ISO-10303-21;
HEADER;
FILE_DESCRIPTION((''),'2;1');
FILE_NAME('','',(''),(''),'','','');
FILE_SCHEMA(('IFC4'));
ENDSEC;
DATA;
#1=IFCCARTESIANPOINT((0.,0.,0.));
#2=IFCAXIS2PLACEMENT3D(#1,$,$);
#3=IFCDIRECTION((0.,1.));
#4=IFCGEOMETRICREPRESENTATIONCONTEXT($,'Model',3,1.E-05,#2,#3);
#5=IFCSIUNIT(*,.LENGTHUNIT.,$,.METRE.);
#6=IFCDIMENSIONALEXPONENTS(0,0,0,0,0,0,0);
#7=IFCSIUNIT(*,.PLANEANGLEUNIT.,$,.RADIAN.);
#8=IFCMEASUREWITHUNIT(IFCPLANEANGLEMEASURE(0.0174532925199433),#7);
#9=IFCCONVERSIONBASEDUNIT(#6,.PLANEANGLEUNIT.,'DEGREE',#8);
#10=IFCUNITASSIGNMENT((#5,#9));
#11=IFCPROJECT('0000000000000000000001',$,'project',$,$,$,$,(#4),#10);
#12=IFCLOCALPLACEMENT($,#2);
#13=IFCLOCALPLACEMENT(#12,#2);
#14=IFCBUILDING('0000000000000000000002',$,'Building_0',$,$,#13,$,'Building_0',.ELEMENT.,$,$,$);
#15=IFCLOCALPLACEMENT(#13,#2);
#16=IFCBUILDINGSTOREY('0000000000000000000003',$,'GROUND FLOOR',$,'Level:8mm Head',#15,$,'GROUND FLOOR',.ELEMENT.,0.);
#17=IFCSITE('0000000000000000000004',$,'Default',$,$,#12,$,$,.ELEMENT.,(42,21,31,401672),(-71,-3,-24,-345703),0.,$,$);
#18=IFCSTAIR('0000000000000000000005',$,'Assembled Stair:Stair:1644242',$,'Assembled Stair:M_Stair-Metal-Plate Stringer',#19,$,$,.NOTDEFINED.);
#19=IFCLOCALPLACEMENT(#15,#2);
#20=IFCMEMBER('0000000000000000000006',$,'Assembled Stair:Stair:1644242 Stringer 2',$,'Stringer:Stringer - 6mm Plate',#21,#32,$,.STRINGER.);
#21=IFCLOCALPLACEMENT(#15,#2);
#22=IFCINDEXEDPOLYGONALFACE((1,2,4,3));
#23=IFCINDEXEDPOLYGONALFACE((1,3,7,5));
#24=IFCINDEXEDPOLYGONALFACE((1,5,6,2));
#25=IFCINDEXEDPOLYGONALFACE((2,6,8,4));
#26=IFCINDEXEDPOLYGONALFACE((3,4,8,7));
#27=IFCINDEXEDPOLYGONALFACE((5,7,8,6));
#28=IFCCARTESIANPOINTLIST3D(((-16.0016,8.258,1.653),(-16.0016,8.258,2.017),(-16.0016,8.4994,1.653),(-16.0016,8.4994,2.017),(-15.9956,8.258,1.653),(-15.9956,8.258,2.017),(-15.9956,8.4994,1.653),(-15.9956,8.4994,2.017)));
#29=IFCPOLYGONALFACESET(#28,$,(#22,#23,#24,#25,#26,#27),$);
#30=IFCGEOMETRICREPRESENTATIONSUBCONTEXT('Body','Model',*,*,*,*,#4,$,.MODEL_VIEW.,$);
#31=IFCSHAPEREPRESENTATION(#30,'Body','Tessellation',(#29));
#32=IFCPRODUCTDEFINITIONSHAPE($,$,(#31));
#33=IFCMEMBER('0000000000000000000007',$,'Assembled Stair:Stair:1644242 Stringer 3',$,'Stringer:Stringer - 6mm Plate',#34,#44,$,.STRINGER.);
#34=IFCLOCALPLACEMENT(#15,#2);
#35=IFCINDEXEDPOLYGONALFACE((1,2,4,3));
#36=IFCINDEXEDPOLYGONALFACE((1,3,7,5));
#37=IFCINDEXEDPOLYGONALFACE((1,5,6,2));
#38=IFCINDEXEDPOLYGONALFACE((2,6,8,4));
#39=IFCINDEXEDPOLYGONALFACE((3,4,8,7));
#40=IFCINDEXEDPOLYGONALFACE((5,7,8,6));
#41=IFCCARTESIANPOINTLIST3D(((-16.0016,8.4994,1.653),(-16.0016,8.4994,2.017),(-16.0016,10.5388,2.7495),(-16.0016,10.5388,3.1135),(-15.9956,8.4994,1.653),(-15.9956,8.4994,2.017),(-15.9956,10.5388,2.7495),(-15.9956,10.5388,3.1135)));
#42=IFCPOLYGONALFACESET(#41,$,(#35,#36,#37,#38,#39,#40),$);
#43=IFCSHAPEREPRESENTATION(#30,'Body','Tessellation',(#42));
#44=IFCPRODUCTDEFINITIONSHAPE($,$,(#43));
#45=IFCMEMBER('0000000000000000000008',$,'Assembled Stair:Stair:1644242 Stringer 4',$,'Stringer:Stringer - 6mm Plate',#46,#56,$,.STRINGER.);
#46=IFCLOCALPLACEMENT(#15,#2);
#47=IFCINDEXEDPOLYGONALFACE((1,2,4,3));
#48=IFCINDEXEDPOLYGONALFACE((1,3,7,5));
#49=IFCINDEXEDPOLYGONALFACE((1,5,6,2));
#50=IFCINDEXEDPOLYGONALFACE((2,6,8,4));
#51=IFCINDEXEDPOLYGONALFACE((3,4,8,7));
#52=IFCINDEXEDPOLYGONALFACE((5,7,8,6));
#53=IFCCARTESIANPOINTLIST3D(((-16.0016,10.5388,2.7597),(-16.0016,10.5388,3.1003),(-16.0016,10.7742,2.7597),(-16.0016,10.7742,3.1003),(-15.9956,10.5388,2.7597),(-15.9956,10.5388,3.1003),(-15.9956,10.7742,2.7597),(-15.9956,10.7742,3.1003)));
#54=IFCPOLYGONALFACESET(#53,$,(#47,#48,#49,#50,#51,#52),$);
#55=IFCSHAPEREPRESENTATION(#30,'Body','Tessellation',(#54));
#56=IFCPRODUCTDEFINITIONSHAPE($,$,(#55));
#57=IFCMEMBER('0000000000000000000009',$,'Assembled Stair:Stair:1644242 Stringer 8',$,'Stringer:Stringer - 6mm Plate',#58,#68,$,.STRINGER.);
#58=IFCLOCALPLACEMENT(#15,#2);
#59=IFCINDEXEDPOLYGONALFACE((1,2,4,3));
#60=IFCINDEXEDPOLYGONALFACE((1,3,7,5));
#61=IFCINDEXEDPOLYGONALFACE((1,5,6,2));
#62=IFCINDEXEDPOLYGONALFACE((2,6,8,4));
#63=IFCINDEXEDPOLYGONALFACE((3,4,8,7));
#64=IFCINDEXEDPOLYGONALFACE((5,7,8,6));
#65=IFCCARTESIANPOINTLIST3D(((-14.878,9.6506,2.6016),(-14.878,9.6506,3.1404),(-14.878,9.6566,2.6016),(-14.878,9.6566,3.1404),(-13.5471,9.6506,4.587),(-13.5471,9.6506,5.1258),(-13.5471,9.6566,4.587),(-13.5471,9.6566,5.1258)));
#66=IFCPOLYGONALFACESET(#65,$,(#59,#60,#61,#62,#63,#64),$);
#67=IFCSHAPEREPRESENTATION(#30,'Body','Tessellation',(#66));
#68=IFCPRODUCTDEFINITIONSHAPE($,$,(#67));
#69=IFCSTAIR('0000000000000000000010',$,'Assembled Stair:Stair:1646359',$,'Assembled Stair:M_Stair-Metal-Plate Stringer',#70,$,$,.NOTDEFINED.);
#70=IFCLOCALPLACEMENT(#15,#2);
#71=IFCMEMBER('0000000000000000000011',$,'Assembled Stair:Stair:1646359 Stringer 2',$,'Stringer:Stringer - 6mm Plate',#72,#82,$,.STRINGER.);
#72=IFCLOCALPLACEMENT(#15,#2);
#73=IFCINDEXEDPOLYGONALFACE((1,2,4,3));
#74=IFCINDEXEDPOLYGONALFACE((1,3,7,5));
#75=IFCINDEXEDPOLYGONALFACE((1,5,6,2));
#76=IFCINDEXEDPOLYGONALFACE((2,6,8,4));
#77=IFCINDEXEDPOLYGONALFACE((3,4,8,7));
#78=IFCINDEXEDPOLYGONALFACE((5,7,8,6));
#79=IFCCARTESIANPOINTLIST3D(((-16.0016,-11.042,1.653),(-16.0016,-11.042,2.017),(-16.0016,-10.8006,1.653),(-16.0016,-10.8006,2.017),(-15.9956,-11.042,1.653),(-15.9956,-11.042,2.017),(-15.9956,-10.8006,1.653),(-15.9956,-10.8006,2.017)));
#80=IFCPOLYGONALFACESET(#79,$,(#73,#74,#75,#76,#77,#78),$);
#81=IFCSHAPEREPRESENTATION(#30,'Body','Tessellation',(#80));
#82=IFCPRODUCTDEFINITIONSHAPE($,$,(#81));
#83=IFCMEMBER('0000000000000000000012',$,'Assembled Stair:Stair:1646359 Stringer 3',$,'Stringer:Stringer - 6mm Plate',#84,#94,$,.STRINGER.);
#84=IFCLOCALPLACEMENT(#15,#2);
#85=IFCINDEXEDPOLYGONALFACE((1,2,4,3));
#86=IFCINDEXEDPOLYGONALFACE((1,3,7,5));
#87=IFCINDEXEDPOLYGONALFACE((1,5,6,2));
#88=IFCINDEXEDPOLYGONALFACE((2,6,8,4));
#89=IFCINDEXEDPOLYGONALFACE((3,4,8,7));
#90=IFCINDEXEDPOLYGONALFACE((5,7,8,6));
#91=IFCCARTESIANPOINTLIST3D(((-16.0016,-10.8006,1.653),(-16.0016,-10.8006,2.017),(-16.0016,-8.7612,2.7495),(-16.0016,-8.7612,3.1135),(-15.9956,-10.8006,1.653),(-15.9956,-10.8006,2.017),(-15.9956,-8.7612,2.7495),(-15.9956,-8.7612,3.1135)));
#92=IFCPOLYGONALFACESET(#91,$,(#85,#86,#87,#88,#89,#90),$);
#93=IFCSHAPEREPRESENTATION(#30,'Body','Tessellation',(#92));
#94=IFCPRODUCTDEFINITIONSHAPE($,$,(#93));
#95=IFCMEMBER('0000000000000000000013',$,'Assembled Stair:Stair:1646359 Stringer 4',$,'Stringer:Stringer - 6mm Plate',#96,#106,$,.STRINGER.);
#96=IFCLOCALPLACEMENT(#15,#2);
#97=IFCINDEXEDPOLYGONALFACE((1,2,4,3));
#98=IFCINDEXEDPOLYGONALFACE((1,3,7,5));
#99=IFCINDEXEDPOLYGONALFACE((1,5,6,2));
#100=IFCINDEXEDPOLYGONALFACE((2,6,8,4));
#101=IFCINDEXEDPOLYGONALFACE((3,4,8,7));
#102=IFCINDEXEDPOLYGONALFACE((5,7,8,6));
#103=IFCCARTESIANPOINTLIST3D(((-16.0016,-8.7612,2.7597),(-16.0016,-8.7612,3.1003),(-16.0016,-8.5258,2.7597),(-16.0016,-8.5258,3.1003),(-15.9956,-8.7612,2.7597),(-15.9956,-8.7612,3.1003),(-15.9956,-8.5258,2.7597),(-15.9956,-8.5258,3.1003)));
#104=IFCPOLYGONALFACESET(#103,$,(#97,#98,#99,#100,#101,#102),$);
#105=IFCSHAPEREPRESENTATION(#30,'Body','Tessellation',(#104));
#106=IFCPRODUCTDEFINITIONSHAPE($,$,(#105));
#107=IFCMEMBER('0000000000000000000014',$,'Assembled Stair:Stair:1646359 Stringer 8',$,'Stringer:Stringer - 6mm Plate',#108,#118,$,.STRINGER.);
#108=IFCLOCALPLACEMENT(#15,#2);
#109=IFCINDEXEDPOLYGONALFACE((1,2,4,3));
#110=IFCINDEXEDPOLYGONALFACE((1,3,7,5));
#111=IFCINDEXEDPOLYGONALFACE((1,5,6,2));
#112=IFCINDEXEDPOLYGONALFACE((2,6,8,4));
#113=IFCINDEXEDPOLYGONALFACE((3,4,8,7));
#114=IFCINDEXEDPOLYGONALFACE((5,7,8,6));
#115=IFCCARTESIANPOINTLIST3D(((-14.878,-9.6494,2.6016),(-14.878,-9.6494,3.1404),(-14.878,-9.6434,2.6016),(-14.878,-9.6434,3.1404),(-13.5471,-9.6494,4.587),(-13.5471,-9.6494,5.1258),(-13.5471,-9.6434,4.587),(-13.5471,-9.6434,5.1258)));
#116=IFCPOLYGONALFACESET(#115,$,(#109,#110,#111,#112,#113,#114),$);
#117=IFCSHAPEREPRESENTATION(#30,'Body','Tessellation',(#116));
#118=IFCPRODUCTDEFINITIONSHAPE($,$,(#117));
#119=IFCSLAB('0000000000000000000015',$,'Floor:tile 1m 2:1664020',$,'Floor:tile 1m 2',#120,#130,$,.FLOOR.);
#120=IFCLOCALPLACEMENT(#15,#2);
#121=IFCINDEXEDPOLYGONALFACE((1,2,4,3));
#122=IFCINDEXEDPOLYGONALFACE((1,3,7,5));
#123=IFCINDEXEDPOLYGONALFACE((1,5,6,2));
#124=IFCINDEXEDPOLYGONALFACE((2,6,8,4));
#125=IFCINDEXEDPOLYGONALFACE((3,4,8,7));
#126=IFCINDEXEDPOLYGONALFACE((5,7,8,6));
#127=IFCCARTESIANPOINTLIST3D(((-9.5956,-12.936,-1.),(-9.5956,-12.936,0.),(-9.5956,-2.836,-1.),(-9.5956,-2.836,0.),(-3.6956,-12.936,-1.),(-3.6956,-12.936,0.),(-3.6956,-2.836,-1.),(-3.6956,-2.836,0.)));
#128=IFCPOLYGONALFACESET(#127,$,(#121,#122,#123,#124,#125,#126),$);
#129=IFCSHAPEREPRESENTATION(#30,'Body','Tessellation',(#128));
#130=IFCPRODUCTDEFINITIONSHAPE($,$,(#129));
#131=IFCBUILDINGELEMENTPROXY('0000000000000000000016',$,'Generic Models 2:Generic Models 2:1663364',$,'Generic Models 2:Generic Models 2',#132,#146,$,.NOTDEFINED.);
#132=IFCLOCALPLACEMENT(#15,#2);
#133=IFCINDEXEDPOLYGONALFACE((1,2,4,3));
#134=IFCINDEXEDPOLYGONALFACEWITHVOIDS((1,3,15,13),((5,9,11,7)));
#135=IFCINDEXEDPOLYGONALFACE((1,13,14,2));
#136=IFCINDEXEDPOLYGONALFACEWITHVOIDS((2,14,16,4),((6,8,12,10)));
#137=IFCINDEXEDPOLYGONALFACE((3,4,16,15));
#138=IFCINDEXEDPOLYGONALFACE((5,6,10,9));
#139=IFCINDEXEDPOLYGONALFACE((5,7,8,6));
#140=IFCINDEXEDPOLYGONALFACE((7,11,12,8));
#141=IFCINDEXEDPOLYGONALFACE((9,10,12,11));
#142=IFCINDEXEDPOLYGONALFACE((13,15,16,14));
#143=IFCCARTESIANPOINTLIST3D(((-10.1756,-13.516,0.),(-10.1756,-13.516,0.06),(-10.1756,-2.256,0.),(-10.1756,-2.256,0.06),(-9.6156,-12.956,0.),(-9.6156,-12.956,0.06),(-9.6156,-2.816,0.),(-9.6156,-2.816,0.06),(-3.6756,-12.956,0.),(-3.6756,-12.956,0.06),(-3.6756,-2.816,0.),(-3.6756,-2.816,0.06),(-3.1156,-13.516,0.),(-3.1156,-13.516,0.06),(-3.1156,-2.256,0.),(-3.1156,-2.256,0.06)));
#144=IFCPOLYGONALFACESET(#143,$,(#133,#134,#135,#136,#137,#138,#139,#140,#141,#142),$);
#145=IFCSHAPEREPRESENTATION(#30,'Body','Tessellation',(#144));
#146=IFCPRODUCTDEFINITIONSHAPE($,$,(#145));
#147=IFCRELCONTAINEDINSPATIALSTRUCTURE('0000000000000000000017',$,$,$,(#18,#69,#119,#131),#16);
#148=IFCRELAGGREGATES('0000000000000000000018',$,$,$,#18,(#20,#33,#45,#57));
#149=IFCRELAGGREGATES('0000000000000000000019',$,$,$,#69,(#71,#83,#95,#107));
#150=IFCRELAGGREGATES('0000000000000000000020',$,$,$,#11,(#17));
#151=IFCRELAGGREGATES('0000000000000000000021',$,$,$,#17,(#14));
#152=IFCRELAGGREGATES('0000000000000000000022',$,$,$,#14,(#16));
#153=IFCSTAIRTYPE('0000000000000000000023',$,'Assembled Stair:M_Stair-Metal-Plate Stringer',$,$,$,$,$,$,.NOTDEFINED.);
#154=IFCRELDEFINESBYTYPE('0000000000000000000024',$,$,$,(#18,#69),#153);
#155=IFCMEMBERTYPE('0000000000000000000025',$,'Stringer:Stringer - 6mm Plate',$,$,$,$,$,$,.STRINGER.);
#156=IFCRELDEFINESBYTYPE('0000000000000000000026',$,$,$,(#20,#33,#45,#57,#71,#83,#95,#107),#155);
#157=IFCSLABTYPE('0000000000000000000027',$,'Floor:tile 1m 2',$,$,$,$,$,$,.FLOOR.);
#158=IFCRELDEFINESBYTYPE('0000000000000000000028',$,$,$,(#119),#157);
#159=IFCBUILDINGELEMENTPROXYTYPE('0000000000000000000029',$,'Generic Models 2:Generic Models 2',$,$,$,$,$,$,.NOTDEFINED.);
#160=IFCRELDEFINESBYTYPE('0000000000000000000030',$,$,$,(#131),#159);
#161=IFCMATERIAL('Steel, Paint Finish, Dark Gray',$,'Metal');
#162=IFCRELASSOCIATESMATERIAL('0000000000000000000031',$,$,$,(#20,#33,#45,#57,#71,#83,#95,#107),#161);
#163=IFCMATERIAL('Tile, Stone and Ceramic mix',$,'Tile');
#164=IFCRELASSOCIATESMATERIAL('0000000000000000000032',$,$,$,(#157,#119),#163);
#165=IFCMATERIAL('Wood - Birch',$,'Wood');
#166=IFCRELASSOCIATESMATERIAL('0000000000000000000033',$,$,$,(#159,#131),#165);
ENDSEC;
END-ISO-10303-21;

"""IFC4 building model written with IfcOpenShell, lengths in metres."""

from ifc_helpers import new_model, entity, si_unit, converted_unit, direction, frame, origin, place, context, subcontext, project, spatial, indexed_curve, outline, extrude, source, transform, mapped, material, type_object, type_shapes, element, aggregate, save


model = new_model("IFC4")

# Units and contexts
model_context = context("Model", 3, precision=1e-05, world=origin(), true_north=direction((0.0, 1.0)))
body_context = subcontext(model_context, "Body", "Model", "MODEL_VIEW")
ifc_project = project(units=[si_unit("LENGTHUNIT", "METRE"), converted_unit("PLANEANGLEUNIT", "DEGREE", entity("IfcPlaneAngleMeasure", 0.0174532925199433), si_unit("PLANEANGLEUNIT", "RADIAN"), dimensions=[0, 0, 0, 0, 0, 0, 0])], contexts=[model_context])

# Site, building, storey
site_placement = place(None, origin())
site = spatial("IfcSite", under=ifc_project, at=site_placement, Name="Default", CompositionType="ELEMENT", RefLatitude=(42, 21, 31, 401672), RefLongitude=(-71, -3, -24, -345703), RefElevation=0.0)
building_placement = place(site_placement, origin())
building = spatial("IfcBuilding", under=site, at=building_placement, Name="Building_0", LongName="Building_0", CompositionType="ELEMENT")
storey_placement = place(building_placement, origin())
storey = spatial("IfcBuildingStorey", under=building, at=storey_placement, Name="GROUND FLOOR", ObjectType="Level:8mm Head", LongName="GROUND FLOOR", CompositionType="ELEMENT", Elevation=0.0)

# Stairs, members
stair_type = type_object("IfcStairType", Name="Assembled Stair:M_Stair-Metal-Plate Stringer", PredefinedType="NOTDEFINED")
stair_1_placement = place(storey_placement, origin())
stair_1 = element("IfcStair", 1, at=stair_1_placement, inside=storey, type_object=stair_type, Name="Assembled Stair:Stair:1644242", ObjectType="Assembled Stair:M_Stair-Metal-Plate Stringer", PredefinedType="NOTDEFINED")
ifc_material_1 = material(Name="Steel, Paint Finish, Dark Gray", Category="Metal")
member_type = type_object("IfcMemberType", Name="Stringer:Stringer - 6mm Plate", PredefinedType="STRINGER")
member_1_placement = place(stair_1_placement, origin())
member_1 = element("IfcMember", 2, at=member_1_placement, type_object=member_type, material=ifc_material_1, Name="Assembled Stair:Stair:1644242 Stringer 2", ObjectType="Stringer:Stringer - 6mm Plate", PredefinedType="STRINGER", context=body_context, shape_type="SweptSolid", body=[
    extrude(outline(indexed_curve([(-0.1207, -0.003), (0.1207, -0.003), (0.1207, 0.003), (-0.1207, 0.003), (-0.1207, -0.003)], self_intersect=False)), frame((-15.9986, 8.3787, 1.653), z_axis=(0.0, 0.0, 1.0), x_axis=(0.0, 1.0, 0.0)), (0.0, 0.0, 1.0), 0.364),
])
member_2_placement = place(stair_1_placement, origin())
member_2 = element("IfcMember", 3, at=member_2_placement, type_object=member_type, material=ifc_material_1, Name="Assembled Stair:Stair:1644242 Stringer 3", ObjectType="Stringer:Stringer - 6mm Plate", PredefinedType="STRINGER", context=body_context, shape_type="SweptSolid", body=[
    extrude(outline(indexed_curve([(-1.2439, -0.1603), (1.0716, -0.1603), (1.2439, 0.1603), (-1.0716, 0.1603), (-1.2439, -0.1603)], self_intersect=False)), frame((-16.0016, 9.5191, 2.3833), z_axis=(1.0, 0.0, 0.0), x_axis=(0.0, 0.880753, 0.473576)), (0.0, 0.0, 1.0), 0.006),
])
member_3_placement = place(stair_1_placement, origin())
member_3 = element("IfcMember", 4, at=member_3_placement, type_object=member_type, material=ifc_material_1, Name="Assembled Stair:Stair:1644242 Stringer 4", ObjectType="Stringer:Stringer - 6mm Plate", PredefinedType="STRINGER", context=body_context, shape_type="SweptSolid", body=[
    extrude(outline(indexed_curve([(-0.1177, -0.003), (0.1177, -0.003), (0.1177, 0.003), (-0.1177, 0.003), (-0.1177, -0.003)], self_intersect=False)), frame((-15.9986, 10.6565, 2.7597), z_axis=(0.0, 0.0, 1.0), x_axis=(0.0, 1.0, 0.0)), (0.0, 0.0, 1.0), 0.3406),
])
member_4_placement = place(stair_1_placement, origin())
member_4 = element("IfcMember", 5, at=member_4_placement, type_object=member_type, material=ifc_material_1, Name="Assembled Stair:Stair:1644242 Stringer 8", ObjectType="Stringer:Stringer - 6mm Plate", PredefinedType="STRINGER", context=body_context, shape_type="SweptSolid", body=[
    extrude(outline(indexed_curve([(-0.9713, -0.15), (1.4188, -0.15), (0.9713, 0.15), (-1.4188, 0.15), (-0.9713, -0.15)], self_intersect=False)), frame((-14.2126, 9.6506, 3.8637), z_axis=(0.0, 1.0, 0.0), x_axis=(0.556804, 0.0, 0.830644)), (0.0, 0.0, 1.0), 0.006),
])
aggregate(stair_1, [member_1, member_2, member_3, member_4])
stair_2_placement = place(storey_placement, origin())
stair_2 = element("IfcStair", 6, at=stair_2_placement, inside=storey, type_object=stair_type, Name="Assembled Stair:Stair:1646359", ObjectType="Assembled Stair:M_Stair-Metal-Plate Stringer", PredefinedType="NOTDEFINED")
member_5_placement = place(stair_2_placement, origin())
member_5 = element("IfcMember", 7, at=member_5_placement, type_object=member_type, material=ifc_material_1, Name="Assembled Stair:Stair:1646359 Stringer 2", ObjectType="Stringer:Stringer - 6mm Plate", PredefinedType="STRINGER", context=body_context, shape_type="SweptSolid", body=[
    extrude(outline(indexed_curve([(-0.1207, -0.003), (0.1207, -0.003), (0.1207, 0.003), (-0.1207, 0.003), (-0.1207, -0.003)], self_intersect=False)), frame((-15.9986, -10.9213, 1.653), z_axis=(0.0, 0.0, 1.0), x_axis=(0.0, 1.0, 0.0)), (0.0, 0.0, 1.0), 0.364),
])
member_6_placement = place(stair_2_placement, origin())
member_6 = element("IfcMember", 8, at=member_6_placement, type_object=member_type, material=ifc_material_1, Name="Assembled Stair:Stair:1646359 Stringer 3", ObjectType="Stringer:Stringer - 6mm Plate", PredefinedType="STRINGER", context=body_context, shape_type="SweptSolid", body=[
    extrude(outline(indexed_curve([(-1.2439, -0.1603), (1.0716, -0.1603), (1.2439, 0.1603), (-1.0716, 0.1603), (-1.2439, -0.1603)], self_intersect=False)), frame((-16.0016, -9.7809, 2.3833), z_axis=(1.0, 0.0, 0.0), x_axis=(0.0, 0.880753, 0.473576)), (0.0, 0.0, 1.0), 0.006),
])
member_7_placement = place(stair_2_placement, origin())
member_7 = element("IfcMember", 9, at=member_7_placement, type_object=member_type, material=ifc_material_1, Name="Assembled Stair:Stair:1646359 Stringer 4", ObjectType="Stringer:Stringer - 6mm Plate", PredefinedType="STRINGER", context=body_context, shape_type="SweptSolid", body=[
    extrude(outline(indexed_curve([(-0.1177, -0.003), (0.1177, -0.003), (0.1177, 0.003), (-0.1177, 0.003), (-0.1177, -0.003)], self_intersect=False)), frame((-15.9986, -8.6435, 2.7597), z_axis=(0.0, 0.0, 1.0), x_axis=(0.0, 1.0, 0.0)), (0.0, 0.0, 1.0), 0.3406),
])
member_8_placement = place(stair_2_placement, origin())
member_8 = element("IfcMember", 10, at=member_8_placement, type_object=member_type, material=ifc_material_1, Name="Assembled Stair:Stair:1646359 Stringer 8", ObjectType="Stringer:Stringer - 6mm Plate", PredefinedType="STRINGER", context=body_context, shape_type="SweptSolid", body=[
    extrude(outline(indexed_curve([(-0.9713, -0.15), (1.4188, -0.15), (0.9713, 0.15), (-1.4188, 0.15), (-0.9713, -0.15)], self_intersect=False)), frame((-14.2126, -9.6494, 3.8637), z_axis=(0.0, 1.0, 0.0), x_axis=(0.556804, 0.0, 0.830644)), (0.0, 0.0, 1.0), 0.006),
])
aggregate(stair_2, [member_5, member_6, member_7, member_8])

# Slab
ifc_material_2 = material(Name="Tile, Stone and Ceramic mix", Category="Tile")
slab_type_1 = type_object("IfcSlabType", Name="Floor:tile 1m 2", PredefinedType="FLOOR", material=ifc_material_2)
slab_1_placement = place(storey_placement, origin())
element("IfcSlab", 11, at=slab_1_placement, inside=storey, type_object=slab_type_1, material=ifc_material_2, Name="Floor:tile 1m 2:1664020", ObjectType="Floor:tile 1m 2", PredefinedType="FLOOR", context=body_context, shape_type="SweptSolid", body=[
    extrude(outline(indexed_curve([(-5.05, -2.95), (5.05, -2.95), (5.05, 2.95), (-5.05, 2.95), (-5.05, -2.95)], self_intersect=False)), frame((-6.6456, -7.886, 0.0), z_axis=(0.0, 0.0, -1.0), x_axis=(0.0, 1.0, 0.0)), (0.0, 0.0, 1.0), 1.0),
])

# Building element proxy
ifc_material_3 = material(Name="Wood - Birch", Category="Wood")
building_element_proxy_type_1 = type_object("IfcBuildingElementProxyType", Name="Generic Models 2:Generic Models 2", PredefinedType="NOTDEFINED", material=ifc_material_3)
shared_shape_1 = source(origin(), body_context, "Body", "SweptSolid", [
    extrude(outline(indexed_curve([(-3.53, -5.63), (3.53, -5.63), (3.53, 5.63), (-3.53, 5.63), (-3.53, -5.63)], self_intersect=False), holes=[indexed_curve([(-2.97, -5.07), (-2.97, 5.07), (2.97, 5.07), (2.97, -5.07), (-2.97, -5.07)], self_intersect=False)]), frame((-6.6456, -7.886, 0.0), z_axis=(0.0, 0.0, 1.0), x_axis=(-1.0, 0.0, 0.0)), (0.0, 0.0, 1.0), 0.06),
])
type_shapes(building_element_proxy_type_1, [shared_shape_1])
proxy_1_placement = place(storey_placement, origin())
element("IfcBuildingElementProxy", 12, at=proxy_1_placement, inside=storey, type_object=building_element_proxy_type_1, material=ifc_material_3, Name="Generic Models 2:Generic Models 2:1663364", ObjectType="Generic Models 2:Generic Models 2", PredefinedType="NOTDEFINED", context=body_context, shape_type="MappedRepresentation", body=[
    mapped(shared_shape_1, transform((0.0, 0.0, 0.0), scale=1.0)),
])

save(model, "model.ifc")
